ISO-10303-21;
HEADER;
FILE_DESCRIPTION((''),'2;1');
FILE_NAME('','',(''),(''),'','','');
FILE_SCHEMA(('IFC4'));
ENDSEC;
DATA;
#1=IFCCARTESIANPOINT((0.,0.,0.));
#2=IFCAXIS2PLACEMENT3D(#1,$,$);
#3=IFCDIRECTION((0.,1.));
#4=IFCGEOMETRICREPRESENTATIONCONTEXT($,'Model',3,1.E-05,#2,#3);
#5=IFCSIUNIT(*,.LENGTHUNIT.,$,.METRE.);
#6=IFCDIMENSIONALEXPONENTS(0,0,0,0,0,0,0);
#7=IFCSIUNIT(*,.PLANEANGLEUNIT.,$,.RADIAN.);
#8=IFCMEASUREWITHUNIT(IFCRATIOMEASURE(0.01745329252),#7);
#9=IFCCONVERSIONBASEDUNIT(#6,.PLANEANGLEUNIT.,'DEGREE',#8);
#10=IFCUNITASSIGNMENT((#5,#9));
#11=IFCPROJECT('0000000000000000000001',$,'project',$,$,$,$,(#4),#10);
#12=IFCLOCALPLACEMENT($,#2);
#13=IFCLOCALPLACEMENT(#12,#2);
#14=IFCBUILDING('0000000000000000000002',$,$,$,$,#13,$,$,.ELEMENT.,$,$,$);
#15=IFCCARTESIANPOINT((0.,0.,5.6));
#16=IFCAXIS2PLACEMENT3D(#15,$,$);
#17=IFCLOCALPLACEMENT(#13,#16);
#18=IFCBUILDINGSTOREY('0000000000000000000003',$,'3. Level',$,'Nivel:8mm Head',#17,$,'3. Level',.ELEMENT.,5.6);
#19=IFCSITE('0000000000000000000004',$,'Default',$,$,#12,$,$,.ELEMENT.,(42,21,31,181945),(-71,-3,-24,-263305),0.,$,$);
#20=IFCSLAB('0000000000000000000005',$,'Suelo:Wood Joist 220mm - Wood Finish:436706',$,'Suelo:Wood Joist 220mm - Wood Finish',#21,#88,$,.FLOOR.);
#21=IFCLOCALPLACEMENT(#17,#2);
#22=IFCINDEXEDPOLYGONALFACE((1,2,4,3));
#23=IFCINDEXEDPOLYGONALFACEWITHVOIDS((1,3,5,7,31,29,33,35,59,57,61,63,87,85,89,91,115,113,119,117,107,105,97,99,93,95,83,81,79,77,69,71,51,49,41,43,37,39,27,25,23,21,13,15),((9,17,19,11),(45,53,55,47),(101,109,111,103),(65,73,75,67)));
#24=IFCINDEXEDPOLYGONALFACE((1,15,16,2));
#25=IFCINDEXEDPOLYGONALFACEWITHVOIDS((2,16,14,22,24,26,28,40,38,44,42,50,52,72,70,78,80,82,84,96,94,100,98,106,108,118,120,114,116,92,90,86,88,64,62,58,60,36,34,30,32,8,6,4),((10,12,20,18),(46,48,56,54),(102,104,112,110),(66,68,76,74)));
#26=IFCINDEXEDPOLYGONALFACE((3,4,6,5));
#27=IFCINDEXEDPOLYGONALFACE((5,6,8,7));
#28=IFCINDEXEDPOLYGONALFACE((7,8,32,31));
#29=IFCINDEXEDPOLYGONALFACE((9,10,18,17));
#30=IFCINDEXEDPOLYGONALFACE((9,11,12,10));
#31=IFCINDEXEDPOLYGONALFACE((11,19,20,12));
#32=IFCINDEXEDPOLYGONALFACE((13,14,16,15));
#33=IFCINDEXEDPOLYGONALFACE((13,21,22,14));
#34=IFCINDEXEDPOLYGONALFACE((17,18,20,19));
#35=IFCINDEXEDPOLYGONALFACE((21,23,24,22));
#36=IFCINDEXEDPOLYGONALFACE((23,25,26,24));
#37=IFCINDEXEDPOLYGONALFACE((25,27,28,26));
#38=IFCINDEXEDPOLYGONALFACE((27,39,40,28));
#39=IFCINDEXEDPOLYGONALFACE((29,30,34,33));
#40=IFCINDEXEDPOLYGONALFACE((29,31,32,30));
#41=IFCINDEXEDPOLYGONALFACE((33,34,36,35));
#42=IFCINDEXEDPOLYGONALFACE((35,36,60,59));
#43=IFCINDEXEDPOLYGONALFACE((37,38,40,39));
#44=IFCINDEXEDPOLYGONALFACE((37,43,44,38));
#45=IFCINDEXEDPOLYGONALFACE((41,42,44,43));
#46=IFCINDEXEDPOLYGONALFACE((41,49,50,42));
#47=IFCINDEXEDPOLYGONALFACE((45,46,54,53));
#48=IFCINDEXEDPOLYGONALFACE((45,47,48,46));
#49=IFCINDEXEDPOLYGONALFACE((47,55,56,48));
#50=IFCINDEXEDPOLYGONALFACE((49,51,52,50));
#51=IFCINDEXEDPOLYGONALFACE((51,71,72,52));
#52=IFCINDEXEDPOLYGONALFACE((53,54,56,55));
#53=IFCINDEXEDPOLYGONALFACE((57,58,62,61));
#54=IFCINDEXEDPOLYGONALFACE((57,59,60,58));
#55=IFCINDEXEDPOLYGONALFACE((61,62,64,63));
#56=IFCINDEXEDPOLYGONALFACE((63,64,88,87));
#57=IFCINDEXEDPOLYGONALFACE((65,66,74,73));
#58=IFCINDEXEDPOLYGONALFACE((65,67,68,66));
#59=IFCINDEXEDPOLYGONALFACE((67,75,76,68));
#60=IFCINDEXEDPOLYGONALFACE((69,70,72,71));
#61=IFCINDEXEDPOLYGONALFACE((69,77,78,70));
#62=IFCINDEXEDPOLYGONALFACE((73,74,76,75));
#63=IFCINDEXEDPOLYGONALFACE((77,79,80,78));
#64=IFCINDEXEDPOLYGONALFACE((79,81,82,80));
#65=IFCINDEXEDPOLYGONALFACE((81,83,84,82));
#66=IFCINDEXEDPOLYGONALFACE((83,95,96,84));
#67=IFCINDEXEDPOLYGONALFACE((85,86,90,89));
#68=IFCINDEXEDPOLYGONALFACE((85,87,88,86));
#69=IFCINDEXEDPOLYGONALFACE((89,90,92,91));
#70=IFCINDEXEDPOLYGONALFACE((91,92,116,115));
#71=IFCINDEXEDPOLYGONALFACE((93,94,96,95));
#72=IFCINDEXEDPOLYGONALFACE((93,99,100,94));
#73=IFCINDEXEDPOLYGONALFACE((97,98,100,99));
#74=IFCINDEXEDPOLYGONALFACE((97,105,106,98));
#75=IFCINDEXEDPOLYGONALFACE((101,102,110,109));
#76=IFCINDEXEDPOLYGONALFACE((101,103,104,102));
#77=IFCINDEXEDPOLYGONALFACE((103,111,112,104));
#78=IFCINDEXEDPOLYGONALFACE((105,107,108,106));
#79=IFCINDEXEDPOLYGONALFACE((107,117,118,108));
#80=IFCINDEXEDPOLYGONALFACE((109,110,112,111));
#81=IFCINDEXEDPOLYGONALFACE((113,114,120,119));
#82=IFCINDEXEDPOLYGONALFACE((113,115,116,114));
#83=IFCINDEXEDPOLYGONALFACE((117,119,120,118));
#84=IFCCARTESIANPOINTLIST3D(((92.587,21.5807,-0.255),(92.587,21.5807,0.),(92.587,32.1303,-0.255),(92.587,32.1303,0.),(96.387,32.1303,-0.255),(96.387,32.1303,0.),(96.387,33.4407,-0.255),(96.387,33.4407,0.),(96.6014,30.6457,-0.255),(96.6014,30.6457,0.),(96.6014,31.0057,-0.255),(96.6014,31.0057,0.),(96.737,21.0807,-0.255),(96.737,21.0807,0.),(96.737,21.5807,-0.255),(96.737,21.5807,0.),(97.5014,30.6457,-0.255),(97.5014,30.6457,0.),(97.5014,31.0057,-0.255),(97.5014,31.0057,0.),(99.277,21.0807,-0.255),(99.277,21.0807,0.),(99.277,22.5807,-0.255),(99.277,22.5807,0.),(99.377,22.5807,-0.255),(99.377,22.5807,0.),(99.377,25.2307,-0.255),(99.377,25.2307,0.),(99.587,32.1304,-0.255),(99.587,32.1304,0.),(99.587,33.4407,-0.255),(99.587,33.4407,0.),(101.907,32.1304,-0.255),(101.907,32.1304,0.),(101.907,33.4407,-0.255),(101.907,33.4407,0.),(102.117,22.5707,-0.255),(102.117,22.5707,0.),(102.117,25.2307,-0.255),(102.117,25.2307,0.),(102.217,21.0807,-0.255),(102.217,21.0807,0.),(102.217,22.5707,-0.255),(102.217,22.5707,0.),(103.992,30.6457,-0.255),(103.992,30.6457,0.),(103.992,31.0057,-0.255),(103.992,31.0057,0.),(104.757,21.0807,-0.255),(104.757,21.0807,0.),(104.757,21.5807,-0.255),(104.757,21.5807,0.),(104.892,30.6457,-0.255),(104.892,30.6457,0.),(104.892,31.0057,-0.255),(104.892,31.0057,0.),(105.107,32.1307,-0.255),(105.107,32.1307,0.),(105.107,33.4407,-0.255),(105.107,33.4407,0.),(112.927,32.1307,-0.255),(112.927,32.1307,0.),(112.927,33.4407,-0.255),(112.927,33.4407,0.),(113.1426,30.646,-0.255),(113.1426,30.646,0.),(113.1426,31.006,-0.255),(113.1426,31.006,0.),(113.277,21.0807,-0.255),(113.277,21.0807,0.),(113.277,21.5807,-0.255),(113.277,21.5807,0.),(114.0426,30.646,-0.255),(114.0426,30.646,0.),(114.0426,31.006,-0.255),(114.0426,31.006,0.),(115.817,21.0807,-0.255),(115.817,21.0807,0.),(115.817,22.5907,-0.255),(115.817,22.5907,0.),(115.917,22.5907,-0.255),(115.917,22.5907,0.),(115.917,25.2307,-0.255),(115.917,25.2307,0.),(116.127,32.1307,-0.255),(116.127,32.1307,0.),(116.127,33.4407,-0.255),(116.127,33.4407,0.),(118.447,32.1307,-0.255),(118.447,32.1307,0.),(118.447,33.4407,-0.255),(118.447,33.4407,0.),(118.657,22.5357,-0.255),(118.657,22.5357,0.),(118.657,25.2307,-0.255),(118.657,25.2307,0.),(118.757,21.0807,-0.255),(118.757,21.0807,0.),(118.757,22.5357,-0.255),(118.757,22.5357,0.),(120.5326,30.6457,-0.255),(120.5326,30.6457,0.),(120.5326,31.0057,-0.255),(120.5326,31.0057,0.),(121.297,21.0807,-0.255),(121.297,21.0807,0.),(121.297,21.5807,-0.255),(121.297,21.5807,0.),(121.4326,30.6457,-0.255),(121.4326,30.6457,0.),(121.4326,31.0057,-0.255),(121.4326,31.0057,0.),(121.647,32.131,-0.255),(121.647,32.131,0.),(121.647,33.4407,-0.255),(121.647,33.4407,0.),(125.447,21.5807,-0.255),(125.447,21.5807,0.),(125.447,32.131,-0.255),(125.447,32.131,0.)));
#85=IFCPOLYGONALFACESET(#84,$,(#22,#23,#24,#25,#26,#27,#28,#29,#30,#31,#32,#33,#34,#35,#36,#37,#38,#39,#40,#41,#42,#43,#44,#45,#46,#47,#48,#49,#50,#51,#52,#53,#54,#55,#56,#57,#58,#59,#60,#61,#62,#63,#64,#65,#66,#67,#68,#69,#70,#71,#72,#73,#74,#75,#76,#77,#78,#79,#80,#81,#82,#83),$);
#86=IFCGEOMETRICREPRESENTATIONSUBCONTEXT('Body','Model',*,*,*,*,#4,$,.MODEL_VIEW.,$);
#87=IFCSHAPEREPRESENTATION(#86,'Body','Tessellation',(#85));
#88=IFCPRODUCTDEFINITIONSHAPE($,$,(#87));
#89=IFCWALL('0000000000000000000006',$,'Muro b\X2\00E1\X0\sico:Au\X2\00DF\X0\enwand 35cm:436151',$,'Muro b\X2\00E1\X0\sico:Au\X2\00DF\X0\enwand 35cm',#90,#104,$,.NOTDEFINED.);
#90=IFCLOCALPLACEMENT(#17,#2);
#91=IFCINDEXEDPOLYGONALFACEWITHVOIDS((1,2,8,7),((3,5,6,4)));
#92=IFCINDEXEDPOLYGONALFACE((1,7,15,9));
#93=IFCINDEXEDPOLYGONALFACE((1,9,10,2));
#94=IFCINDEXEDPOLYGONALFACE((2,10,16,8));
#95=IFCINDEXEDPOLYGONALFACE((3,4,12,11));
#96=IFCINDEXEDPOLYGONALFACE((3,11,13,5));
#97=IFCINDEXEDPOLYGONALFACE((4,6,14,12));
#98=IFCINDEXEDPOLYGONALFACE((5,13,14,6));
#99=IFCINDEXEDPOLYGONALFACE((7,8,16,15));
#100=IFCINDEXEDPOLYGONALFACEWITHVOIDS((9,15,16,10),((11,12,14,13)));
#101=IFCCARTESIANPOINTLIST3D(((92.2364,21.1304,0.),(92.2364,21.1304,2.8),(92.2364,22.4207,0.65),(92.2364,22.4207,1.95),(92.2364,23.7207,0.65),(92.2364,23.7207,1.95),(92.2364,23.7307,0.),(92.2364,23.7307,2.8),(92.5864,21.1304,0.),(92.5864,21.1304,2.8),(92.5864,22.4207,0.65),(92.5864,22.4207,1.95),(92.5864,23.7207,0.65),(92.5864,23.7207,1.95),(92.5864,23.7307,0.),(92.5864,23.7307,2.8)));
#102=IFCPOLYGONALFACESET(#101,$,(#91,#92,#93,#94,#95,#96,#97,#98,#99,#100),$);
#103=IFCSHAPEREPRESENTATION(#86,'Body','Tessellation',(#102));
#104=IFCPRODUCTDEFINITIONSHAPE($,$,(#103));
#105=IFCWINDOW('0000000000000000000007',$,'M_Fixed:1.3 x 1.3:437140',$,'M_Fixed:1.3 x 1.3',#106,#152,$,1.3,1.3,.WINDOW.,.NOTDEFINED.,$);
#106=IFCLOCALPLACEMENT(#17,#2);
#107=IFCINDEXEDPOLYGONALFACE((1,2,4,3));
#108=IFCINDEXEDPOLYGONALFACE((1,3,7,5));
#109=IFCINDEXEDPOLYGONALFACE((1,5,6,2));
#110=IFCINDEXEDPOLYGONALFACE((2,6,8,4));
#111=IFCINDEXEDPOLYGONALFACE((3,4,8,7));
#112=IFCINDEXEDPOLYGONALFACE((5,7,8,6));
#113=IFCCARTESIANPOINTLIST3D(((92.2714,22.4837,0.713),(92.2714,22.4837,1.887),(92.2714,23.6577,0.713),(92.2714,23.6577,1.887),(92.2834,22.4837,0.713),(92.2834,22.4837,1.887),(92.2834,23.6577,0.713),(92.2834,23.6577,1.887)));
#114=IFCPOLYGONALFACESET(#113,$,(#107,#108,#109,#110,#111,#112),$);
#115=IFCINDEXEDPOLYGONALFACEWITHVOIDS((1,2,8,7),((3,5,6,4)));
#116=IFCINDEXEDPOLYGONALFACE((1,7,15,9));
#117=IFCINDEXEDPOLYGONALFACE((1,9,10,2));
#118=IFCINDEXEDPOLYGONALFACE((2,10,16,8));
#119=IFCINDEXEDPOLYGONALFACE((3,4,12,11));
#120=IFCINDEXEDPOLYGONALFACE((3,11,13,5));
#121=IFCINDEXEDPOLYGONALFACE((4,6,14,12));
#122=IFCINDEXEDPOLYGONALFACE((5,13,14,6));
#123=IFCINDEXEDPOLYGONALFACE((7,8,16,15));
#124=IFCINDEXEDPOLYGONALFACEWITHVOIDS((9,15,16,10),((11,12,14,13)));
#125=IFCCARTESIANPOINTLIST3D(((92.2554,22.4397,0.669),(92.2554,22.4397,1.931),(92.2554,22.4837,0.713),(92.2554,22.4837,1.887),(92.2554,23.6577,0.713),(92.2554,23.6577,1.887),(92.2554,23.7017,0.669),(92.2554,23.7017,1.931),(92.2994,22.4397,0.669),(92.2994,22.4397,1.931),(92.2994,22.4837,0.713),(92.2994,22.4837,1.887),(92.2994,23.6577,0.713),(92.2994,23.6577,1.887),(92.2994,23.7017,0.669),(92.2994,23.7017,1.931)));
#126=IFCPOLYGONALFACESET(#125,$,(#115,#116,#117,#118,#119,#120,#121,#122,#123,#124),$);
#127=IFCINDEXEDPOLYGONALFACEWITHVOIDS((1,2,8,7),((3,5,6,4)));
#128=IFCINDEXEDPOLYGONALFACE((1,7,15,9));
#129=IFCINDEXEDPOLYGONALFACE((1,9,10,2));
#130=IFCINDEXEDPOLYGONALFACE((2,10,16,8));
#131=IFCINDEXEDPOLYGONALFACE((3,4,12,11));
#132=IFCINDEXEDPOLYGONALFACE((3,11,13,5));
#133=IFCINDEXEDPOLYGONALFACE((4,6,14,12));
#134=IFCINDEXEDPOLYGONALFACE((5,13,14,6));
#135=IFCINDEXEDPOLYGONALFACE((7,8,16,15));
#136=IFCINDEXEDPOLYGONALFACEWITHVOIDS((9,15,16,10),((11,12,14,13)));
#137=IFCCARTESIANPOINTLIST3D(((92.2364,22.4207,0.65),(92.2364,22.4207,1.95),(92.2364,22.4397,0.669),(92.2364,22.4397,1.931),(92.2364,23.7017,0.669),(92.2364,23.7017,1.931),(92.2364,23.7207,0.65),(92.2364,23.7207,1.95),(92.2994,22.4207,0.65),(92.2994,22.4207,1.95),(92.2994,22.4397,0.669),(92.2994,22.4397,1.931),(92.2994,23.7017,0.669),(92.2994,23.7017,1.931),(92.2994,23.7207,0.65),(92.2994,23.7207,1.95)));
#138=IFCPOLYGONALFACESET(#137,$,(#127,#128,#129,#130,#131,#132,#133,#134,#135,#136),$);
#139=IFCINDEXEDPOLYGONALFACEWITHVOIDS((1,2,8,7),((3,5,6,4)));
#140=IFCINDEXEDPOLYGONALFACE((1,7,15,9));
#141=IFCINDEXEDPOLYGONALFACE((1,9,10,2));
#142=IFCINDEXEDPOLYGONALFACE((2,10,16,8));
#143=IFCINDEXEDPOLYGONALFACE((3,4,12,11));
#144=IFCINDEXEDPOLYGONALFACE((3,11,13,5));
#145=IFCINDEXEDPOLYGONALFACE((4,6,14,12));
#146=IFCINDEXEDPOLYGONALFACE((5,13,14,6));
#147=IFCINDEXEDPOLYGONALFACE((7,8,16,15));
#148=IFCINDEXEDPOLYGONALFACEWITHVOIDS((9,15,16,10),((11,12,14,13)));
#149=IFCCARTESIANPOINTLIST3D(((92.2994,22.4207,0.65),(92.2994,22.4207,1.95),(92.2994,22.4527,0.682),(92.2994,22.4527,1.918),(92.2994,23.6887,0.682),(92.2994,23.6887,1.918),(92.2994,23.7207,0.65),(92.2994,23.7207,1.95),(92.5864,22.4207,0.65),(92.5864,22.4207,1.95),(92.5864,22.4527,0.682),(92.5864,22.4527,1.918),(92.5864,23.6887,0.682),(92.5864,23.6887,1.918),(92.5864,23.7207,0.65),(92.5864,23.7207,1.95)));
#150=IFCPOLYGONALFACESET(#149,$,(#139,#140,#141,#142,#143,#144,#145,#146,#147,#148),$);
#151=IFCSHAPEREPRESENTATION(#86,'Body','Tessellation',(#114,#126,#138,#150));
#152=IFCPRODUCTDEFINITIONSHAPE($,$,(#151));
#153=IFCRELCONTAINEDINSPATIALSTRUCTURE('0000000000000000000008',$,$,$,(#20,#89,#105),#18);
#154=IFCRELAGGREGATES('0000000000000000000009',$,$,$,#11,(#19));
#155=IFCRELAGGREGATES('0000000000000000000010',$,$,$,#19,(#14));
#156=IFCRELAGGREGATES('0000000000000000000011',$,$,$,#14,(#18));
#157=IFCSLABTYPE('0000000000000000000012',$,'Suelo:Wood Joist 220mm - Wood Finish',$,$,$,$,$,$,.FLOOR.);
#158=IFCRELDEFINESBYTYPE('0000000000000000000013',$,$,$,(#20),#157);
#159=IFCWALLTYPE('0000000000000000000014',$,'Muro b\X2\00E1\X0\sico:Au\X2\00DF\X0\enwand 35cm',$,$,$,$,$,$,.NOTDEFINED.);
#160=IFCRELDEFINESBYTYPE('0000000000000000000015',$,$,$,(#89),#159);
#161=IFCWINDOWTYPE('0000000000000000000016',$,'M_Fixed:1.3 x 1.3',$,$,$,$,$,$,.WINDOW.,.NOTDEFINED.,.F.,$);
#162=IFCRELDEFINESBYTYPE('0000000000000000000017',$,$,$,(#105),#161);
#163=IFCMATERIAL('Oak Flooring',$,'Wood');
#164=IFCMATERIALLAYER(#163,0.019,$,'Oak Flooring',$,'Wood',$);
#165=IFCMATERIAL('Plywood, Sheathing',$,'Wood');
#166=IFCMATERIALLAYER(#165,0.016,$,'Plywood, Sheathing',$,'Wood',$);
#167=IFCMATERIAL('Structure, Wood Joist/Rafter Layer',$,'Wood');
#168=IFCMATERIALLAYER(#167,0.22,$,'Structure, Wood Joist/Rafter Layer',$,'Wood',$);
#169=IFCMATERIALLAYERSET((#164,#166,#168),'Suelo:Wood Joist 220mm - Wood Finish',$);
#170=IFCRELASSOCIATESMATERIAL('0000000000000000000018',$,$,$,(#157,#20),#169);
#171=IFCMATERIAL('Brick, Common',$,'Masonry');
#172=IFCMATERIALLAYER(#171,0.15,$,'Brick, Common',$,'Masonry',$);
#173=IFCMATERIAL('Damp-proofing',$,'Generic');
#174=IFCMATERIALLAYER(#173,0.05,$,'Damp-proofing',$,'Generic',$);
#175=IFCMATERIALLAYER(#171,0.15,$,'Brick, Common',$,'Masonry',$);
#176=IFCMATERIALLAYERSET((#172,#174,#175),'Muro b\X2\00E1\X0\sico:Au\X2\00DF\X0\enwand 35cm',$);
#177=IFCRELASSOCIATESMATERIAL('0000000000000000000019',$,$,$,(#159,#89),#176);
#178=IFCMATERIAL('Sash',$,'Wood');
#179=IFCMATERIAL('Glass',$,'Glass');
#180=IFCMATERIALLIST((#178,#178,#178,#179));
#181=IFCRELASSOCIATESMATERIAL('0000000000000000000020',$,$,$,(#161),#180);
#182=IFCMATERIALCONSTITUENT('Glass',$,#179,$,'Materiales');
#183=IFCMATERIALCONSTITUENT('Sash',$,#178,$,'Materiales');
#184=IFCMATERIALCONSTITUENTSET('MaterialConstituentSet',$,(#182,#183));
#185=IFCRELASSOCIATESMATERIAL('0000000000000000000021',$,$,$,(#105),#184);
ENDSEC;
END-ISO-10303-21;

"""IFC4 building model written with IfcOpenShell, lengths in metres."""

from ifc_helpers import new_model, entity, si_unit, converted_unit, direction, frame, frame_2d, origin, origin_2d_with_axis, place, context, subcontext, project, spatial, polyline, rectangle, outline, extrude, source, transform, mapped, material, material_list, layer, layer_set, layer_usage, constituent, constituent_set, type_object, type_shapes, element, fill, save


model = new_model("IFC4")

# Units and contexts
model_context = context("Model", 3, precision=1e-05, world=origin(), true_north=direction((0.0, 1.0)))
body_context = subcontext(model_context, "Body", "Model", "MODEL_VIEW")
ifc_project = project(units=[si_unit("LENGTHUNIT", "METRE"), converted_unit("PLANEANGLEUNIT", "DEGREE", entity("IfcRatioMeasure", 0.01745329252), si_unit("PLANEANGLEUNIT", "RADIAN"), dimensions=[0, 0, 0, 0, 0, 0, 0])], contexts=[model_context])

# Site, building, storey
site_placement = place(None, origin())
site = spatial("IfcSite", under=ifc_project, at=site_placement, Name="Default", CompositionType="ELEMENT", RefLatitude=(42, 21, 31, 181945), RefLongitude=(-71, -3, -24, -263305), RefElevation=0.0)
building_placement = place(site_placement, origin())
building = spatial("IfcBuilding", under=site, at=building_placement, CompositionType="ELEMENT")
storey_placement = place(building_placement, frame((0.0, 0.0, 5.6)))
storey = spatial("IfcBuildingStorey", under=building, at=storey_placement, Name="3. Level", ObjectType="Nivel:8mm Head", LongName="3. Level", CompositionType="ELEMENT", Elevation=5.6)

# Slab, openings
ifc_material_1 = material(Name="Oak Flooring", Category="Wood")
ifc_layer_1 = layer(ifc_material_1, 0.019, Name="Oak Flooring", Category="Wood")
ifc_material_2 = material(Name="Plywood, Sheathing", Category="Wood")
ifc_layer_2 = layer(ifc_material_2, 0.016, Name="Plywood, Sheathing", Category="Wood")
ifc_material_3 = material(Name="Structure, Wood Joist/Rafter Layer", Category="Wood")
ifc_layer_3 = layer(ifc_material_3, 0.22, Name="Structure, Wood Joist/Rafter Layer", Category="Wood")
ifc_layer_set_1 = layer_set([ifc_layer_1, ifc_layer_2, ifc_layer_3], Name="Suelo:Wood Joist 220mm - Wood Finish")
ifc_layer_usage_1 = layer_usage(ifc_layer_set_1, "AXIS3", "POSITIVE", 0.0)
slab_type = type_object("IfcSlabType", Name="Suelo:Wood Joist 220mm - Wood Finish", PredefinedType="FLOOR", material=ifc_layer_set_1)
slab_placement = place(storey_placement, frame((92.587, 21.0807, -0.255)))
slab = element("IfcSlab", 1, at=slab_placement, inside=storey, type_object=slab_type, material=ifc_layer_usage_1, Name="Suelo:Wood Joist 220mm - Wood Finish:436706", ObjectType="Suelo:Wood Joist 220mm - Wood Finish", PredefinedType="FLOOR", context=body_context, shape_type="SweptSolid", body=[
    extrude(outline(polyline([(16.43, -5.68), (16.43, 4.8697), (12.63, 4.8697), (12.63, 6.18), (9.43, 6.18), (9.43, 4.8697), (7.11, 4.8697), (7.11, 6.18), (3.91, 6.18), (3.91, 4.87), (-3.91, 4.87), (-3.91, 6.18), (-7.11, 6.18), (-7.11, 4.87), (-9.43, 4.87), (-9.43, 6.18), (-12.63, 6.18), (-12.63, 4.8703), (-16.43, 4.8703), (-16.43, -5.68), (-12.28, -5.68), (-12.28, -6.18), (-9.74, -6.18), (-9.74, -4.725), (-9.64, -4.725), (-9.64, -2.03), (-6.9, -2.03), (-6.9, -4.67), (-6.8, -4.67), (-6.8, -6.18), (-4.26, -6.18), (-4.26, -5.68), (4.26, -5.68), (4.26, -6.18), (6.8, -6.18), (6.8, -4.69), (6.9, -4.69), (6.9, -2.03), (9.64, -2.03), (9.64, -4.68), (9.74, -4.68), (9.74, -6.18), (12.28, -6.18), (12.28, -5.68), (16.43, -5.68)])), frame((16.43, 6.18, 0.255), z_axis=(0.0, 0.0, -1.0), x_axis=(-1.0, 0.0, 0.0)), (0.0, 0.0, 1.0), 0.255),
])
opening_1_placement = place(storey_placement, frame((92.587, 21.0807, -0.255)))
element("IfcOpeningElement", 2, at=opening_1_placement, cuts=slab, ObjectType="Opening", context=body_context, shape_type="SweptSolid", body=[
    extrude(rectangle(XDim=0.36, YDim=0.9, at=frame_2d((11.9656, 3.565), x_axis=(0.0, -1.0))), frame((16.43, 6.18, 0.255), z_axis=(0.0, 0.0, -1.0), x_axis=(-1.0, 0.0, 0.0)), (0.0, 0.0, 1.0), 0.255),
])
opening_2_placement = place(storey_placement, frame((92.587, 21.0807, -0.255)))
element("IfcOpeningElement", 3, at=opening_2_placement, cuts=slab, ObjectType="Opening", context=body_context, shape_type="SweptSolid", body=[
    extrude(rectangle(XDim=0.36, YDim=0.9, at=frame_2d((4.575, 3.565), x_axis=(0.0, -1.0))), frame((16.43, 6.18, 0.255), z_axis=(0.0, 0.0, -1.0), x_axis=(-1.0, 0.0, 0.0)), (0.0, 0.0, 1.0), 0.255),
])
opening_3_placement = place(storey_placement, frame((92.587, 21.0807, -0.255)))
element("IfcOpeningElement", 4, at=opening_3_placement, cuts=slab, ObjectType="Opening", context=body_context, shape_type="SweptSolid", body=[
    extrude(rectangle(XDim=0.36, YDim=0.9, at=frame_2d((-4.5756, 3.5653), x_axis=(0.0, -1.0))), frame((16.43, 6.18, 0.255), z_axis=(0.0, 0.0, -1.0), x_axis=(-1.0, 0.0, 0.0)), (0.0, 0.0, 1.0), 0.255),
])
opening_4_placement = place(storey_placement, frame((92.587, 21.0807, -0.255)))
element("IfcOpeningElement", 5, at=opening_4_placement, cuts=slab, ObjectType="Opening", context=body_context, shape_type="SweptSolid", body=[
    extrude(rectangle(XDim=0.36, YDim=0.9, at=frame_2d((-11.9656, 3.565), x_axis=(0.0, -1.0))), frame((16.43, 6.18, 0.255), z_axis=(0.0, 0.0, -1.0), x_axis=(-1.0, 0.0, 0.0)), (0.0, 0.0, 1.0), 0.255),
])

# Wall, opening, window
ifc_material_4 = material(Name="Brick, Common", Category="Masonry")
ifc_layer_4 = layer(ifc_material_4, 0.15, Name="Brick, Common", Category="Masonry")
ifc_material_5 = material(Name="Damp-proofing", Category="Generic")
ifc_layer_5 = layer(ifc_material_5, 0.05, Name="Damp-proofing", Category="Generic")
ifc_layer_6 = layer(ifc_material_4, 0.15, Name="Brick, Common", Category="Masonry")
ifc_layer_set_2 = layer_set([ifc_layer_4, ifc_layer_5, ifc_layer_6], Name="Muro básico:Außenwand 35cm")
ifc_layer_usage_2 = layer_usage(ifc_layer_set_2, "AXIS2", "NEGATIVE", 0.175)
wall_type_1 = type_object("IfcWallType", Name="Muro básico:Außenwand 35cm", PredefinedType="NOTDEFINED", material=ifc_layer_set_2)
wall_1_placement = place(storey_placement, frame((92.4114, 23.7307, 0.0), z_axis=(0.0, 0.0, 1.0), x_axis=(0.0, -1.0, 0.0)))
wall_1 = element("IfcWall", 6, at=wall_1_placement, inside=storey, type_object=wall_type_1, material=ifc_layer_usage_2, Name="Muro básico:Außenwand 35cm:436151", ObjectType="Muro básico:Außenwand 35cm", PredefinedType="NOTDEFINED", context=body_context, shape_type="SweptSolid", body=[
    extrude(rectangle(XDim=2.6003, YDim=0.35, at=frame_2d((1.3002, 0.0), x_axis=(-1.0, 0.0))), origin(), (0.0, 0.0, 1.0), 2.8),
])
opening_5_placement = place(wall_1_placement, frame((1.31, 0.175, 0.65)))
opening_5 = element("IfcOpeningElement", 7, at=opening_5_placement, cuts=wall_1, ObjectType="Opening", PredefinedType="OPENING", context=body_context, shape_type="SweptSolid", body=[
    extrude(rectangle(XDim=1.3, YDim=1.3, at=frame_2d((0.65, 0.65), x_axis=(1.0, 0.0))), frame((0.0, 0.0, 0.0), z_axis=(0.0, -1.0, 0.0), x_axis=(0.0, 0.0, 1.0)), (0.0, 0.0, 1.0), 0.35),
])
ifc_material_6 = material(Name="Glass", Category="Glass")
ifc_constituent_1 = constituent(ifc_material_6, Name="Glass", Category="Materiales")
ifc_material_7 = material(Name="Sash", Category="Wood")
ifc_constituent_2 = constituent(ifc_material_7, Name="Sash", Category="Materiales")
ifc_constituent_set_1 = constituent_set(constituents=[ifc_constituent_1, ifc_constituent_2], Name="MaterialConstituentSet")
ifc_material_list_1 = material_list([ifc_material_7, ifc_material_7, ifc_material_7, ifc_material_6])
window_type = type_object("IfcWindowType", Name="M_Fixed:1.3 x 1.3", ParameterTakesPrecedence=False, PartitioningType="NOTDEFINED", PredefinedType="WINDOW", material=ifc_material_list_1)
shared_shape_1 = source(origin(), body_context, "Body", "SweptSolid", [
    extrude(rectangle(XDim=0.012, YDim=1.174, at=origin_2d_with_axis()), frame((0.65, 0.309, 0.063), z_axis=(0.0, 0.0, 1.0), x_axis=(0.0, -1.0, 0.0)), (0.0, 0.0, 1.0), 1.174),
    extrude(outline(polyline([(-0.631, -0.631), (0.631, -0.631), (0.631, 0.631), (-0.631, 0.631), (-0.631, -0.631)]), holes=[polyline([(-0.587, -0.587), (-0.587, 0.587), (0.587, 0.587), (0.587, -0.587), (-0.587, -0.587)])]), frame((0.65, 0.287, 0.65), z_axis=(0.0, 1.0, 0.0), x_axis=(1.0, 0.0, 0.0)), (0.0, 0.0, 1.0), 0.044),
    extrude(outline(polyline([(-0.65, -0.65), (0.65, -0.65), (0.65, 0.65), (-0.65, 0.65), (-0.65, -0.65)]), holes=[polyline([(-0.631, -0.631), (-0.631, 0.631), (0.631, 0.631), (0.631, -0.631), (-0.631, -0.631)])]), frame((0.65, 0.287, 0.65), z_axis=(0.0, 1.0, 0.0), x_axis=(1.0, 0.0, 0.0)), (0.0, 0.0, 1.0), 0.063),
    extrude(outline(polyline([(-0.65, -0.65), (0.65, -0.65), (0.65, 0.65), (-0.65, 0.65), (-0.65, -0.65)]), holes=[polyline([(-0.618, -0.618), (-0.618, 0.618), (0.618, 0.618), (0.618, -0.618), (-0.618, -0.618)])]), frame((0.65, 0.0, 0.65), z_axis=(0.0, 1.0, 0.0), x_axis=(1.0, 0.0, 0.0)), (0.0, 0.0, 1.0), 0.287),
])
type_shapes(window_type, [shared_shape_1])
window_placement = place(opening_5_placement, frame((0.0, 0.0, 0.0), z_axis=(0.0, 0.0, 1.0), x_axis=(-1.0, 0.0, 0.0)))
window = element("IfcWindow", 8, at=window_placement, inside=storey, type_object=window_type, material=ifc_constituent_set_1, Name="M_Fixed:1.3 x 1.3:437140", ObjectType="M_Fixed:1.3 x 1.3", OverallHeight=1.3, OverallWidth=1.3, PartitioningType="NOTDEFINED", PredefinedType="WINDOW", context=body_context, shape_type="MappedRepresentation", body=[
    mapped(shared_shape_1, transform((0.0, 0.0, 0.0), scale=1.0)),
])
fill(opening_5, window)

save(model, "model.ifc")
